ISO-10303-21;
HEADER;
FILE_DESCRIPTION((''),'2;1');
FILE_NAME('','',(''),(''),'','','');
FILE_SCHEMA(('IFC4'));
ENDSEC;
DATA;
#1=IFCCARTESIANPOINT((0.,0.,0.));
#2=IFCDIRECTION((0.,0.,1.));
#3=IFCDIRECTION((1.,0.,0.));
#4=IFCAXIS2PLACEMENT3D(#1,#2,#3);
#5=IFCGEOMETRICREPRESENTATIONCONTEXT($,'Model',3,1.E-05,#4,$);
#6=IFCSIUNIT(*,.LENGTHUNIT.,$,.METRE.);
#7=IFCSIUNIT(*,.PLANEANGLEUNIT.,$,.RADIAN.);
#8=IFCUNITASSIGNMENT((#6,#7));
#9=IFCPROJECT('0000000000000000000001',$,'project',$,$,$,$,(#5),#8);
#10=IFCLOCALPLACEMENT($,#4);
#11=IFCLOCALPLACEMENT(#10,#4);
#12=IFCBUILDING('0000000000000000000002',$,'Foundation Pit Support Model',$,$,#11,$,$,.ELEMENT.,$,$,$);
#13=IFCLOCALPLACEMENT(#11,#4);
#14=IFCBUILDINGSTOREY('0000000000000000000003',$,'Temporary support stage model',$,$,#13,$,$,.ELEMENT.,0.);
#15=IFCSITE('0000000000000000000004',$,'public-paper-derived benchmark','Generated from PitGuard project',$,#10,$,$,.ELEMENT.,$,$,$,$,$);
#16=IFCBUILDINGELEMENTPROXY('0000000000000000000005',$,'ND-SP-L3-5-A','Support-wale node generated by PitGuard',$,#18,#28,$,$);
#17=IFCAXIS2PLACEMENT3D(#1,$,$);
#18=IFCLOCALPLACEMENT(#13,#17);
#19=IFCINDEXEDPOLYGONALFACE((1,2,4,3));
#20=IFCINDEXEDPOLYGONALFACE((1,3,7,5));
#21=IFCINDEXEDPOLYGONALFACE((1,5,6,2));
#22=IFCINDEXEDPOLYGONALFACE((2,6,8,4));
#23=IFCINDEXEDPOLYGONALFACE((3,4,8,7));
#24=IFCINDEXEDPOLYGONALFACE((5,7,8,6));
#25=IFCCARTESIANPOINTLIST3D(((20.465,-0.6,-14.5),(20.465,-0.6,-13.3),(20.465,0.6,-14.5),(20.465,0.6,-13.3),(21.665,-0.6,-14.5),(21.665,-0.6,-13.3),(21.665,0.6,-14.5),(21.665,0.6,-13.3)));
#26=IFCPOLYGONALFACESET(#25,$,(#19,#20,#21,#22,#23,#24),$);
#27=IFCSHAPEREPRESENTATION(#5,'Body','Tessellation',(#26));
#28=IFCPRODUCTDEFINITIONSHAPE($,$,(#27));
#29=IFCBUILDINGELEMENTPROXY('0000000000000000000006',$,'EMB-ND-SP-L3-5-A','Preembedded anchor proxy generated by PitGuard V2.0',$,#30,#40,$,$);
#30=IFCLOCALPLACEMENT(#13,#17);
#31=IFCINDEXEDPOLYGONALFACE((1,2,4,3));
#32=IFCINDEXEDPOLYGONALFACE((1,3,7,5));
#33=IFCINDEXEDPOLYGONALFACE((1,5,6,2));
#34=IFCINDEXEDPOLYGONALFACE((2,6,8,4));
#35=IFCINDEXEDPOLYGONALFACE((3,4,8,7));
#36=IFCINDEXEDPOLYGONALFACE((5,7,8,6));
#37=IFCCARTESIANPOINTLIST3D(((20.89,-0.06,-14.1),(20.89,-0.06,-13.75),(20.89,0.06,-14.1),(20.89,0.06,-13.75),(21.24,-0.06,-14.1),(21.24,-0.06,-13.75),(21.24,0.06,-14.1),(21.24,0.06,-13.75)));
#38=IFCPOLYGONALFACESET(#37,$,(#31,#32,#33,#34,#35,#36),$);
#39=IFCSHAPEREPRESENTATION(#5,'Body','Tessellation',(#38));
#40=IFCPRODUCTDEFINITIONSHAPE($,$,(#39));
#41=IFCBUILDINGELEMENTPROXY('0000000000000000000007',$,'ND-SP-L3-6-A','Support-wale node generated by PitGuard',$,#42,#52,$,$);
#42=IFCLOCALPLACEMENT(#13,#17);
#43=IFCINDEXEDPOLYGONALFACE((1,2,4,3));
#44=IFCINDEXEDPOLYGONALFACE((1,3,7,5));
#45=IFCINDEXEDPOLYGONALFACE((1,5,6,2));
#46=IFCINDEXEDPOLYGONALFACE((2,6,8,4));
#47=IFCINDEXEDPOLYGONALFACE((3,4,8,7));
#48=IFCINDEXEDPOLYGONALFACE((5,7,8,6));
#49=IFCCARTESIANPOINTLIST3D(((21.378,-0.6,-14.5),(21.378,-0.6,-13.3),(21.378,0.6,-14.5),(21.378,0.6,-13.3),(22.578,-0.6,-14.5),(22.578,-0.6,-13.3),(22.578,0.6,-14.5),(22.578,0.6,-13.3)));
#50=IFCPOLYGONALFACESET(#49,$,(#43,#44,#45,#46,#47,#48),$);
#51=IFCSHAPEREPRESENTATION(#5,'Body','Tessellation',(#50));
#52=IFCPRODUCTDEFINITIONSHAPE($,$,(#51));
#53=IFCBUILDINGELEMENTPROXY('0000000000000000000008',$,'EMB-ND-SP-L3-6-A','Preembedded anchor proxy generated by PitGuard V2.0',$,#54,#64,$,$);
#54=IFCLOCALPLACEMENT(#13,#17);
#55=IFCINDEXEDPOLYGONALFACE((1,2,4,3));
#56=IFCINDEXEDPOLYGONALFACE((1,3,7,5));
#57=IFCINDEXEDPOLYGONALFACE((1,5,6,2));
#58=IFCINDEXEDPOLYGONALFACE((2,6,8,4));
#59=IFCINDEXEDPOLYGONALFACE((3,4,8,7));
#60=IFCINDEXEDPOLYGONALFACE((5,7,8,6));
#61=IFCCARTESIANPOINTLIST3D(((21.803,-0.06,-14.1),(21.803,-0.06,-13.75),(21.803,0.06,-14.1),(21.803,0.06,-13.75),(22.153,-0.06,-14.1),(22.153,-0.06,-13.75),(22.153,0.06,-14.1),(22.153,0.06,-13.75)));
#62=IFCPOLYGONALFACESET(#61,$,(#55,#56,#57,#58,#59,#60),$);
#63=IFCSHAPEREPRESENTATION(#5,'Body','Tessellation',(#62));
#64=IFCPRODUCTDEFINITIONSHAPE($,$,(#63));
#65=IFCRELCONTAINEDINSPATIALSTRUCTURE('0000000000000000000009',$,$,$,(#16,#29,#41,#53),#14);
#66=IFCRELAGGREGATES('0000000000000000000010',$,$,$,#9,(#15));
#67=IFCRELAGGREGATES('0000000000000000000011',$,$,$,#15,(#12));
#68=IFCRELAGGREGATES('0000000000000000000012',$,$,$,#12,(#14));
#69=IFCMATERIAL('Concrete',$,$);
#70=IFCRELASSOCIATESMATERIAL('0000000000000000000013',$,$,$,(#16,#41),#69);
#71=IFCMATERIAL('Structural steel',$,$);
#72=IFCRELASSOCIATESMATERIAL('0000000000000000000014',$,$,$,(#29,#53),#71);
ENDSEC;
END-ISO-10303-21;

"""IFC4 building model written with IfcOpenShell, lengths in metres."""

from ifc_helpers import new_model, si_unit, frame, origin_with_axes, origin_2d, place, context, project, spatial, rectangle, extrude, material, element, save


model = new_model("IFC4")

# Units and contexts
model_context = context("Model", 3, precision=1e-05, world=origin_with_axes())
ifc_project = project(units=[si_unit("LENGTHUNIT", "METRE"), si_unit("PLANEANGLEUNIT", "RADIAN")], contexts=[model_context])

# Site, building, storey
site_placement = place(None, origin_with_axes())
site = spatial("IfcSite", under=ifc_project, at=site_placement, Name="public-paper-derived benchmark", Description="Generated from PitGuard project", CompositionType="ELEMENT")
building_placement = place(site_placement, origin_with_axes())
building = spatial("IfcBuilding", under=site, at=building_placement, Name="Foundation Pit Support Model", CompositionType="ELEMENT")
storey_placement = place(building_placement, origin_with_axes())
storey = spatial("IfcBuildingStorey", under=building, at=storey_placement, Name="Temporary support stage model", CompositionType="ELEMENT", Elevation=0.0)

# Shared definitions
ifc_material_1 = material(Name="Structural steel")

# Shared definitions
ifc_material_2 = material(Name="Concrete")

# Building element proxies
proxy_1_placement = place(storey_placement, frame((21.065, 0.0, -14.5), z_axis=(0.0, 0.0, 1.0), x_axis=(1.0, 0.0, 0.0)))
element("IfcBuildingElementProxy", 1, at=proxy_1_placement, inside=storey, material=ifc_material_2, Name="ND-SP-L3-5-A", Description="Support-wale node generated by PitGuard", context=model_context, shape_type="SweptSolid", body=[
    extrude(rectangle(XDim=1.2, YDim=1.2, at=origin_2d()), origin_with_axes(), (0.0, 0.0, 1.0), 1.2),
])
proxy_2_placement = place(storey_placement, frame((21.065, 0.0, -14.1), z_axis=(0.0, 0.0, 1.0), x_axis=(1.0, 0.0, 0.0)))
element("IfcBuildingElementProxy", 2, at=proxy_2_placement, inside=storey, material=ifc_material_1, Name="EMB-ND-SP-L3-5-A", Description="Preembedded anchor proxy generated by PitGuard V2.0", context=model_context, shape_type="SweptSolid", body=[
    extrude(rectangle(XDim=0.35, YDim=0.12, at=origin_2d()), origin_with_axes(), (0.0, 0.0, 1.0), 0.35),
])
proxy_3_placement = place(storey_placement, frame((21.978, 0.0, -14.5), z_axis=(0.0, 0.0, 1.0), x_axis=(1.0, 0.0, 0.0)))
element("IfcBuildingElementProxy", 3, at=proxy_3_placement, inside=storey, material=ifc_material_2, Name="ND-SP-L3-6-A", Description="Support-wale node generated by PitGuard", context=model_context, shape_type="SweptSolid", body=[
    extrude(rectangle(XDim=1.2, YDim=1.2, at=origin_2d()), origin_with_axes(), (0.0, 0.0, 1.0), 1.2),
])
proxy_4_placement = place(storey_placement, frame((21.978, 0.0, -14.1), z_axis=(0.0, 0.0, 1.0), x_axis=(1.0, 0.0, 0.0)))
element("IfcBuildingElementProxy", 4, at=proxy_4_placement, inside=storey, material=ifc_material_1, Name="EMB-ND-SP-L3-6-A", Description="Preembedded anchor proxy generated by PitGuard V2.0", context=model_context, shape_type="SweptSolid", body=[
    extrude(rectangle(XDim=0.35, YDim=0.12, at=origin_2d()), origin_with_axes(), (0.0, 0.0, 1.0), 0.35),
])

save(model, "model.ifc")
